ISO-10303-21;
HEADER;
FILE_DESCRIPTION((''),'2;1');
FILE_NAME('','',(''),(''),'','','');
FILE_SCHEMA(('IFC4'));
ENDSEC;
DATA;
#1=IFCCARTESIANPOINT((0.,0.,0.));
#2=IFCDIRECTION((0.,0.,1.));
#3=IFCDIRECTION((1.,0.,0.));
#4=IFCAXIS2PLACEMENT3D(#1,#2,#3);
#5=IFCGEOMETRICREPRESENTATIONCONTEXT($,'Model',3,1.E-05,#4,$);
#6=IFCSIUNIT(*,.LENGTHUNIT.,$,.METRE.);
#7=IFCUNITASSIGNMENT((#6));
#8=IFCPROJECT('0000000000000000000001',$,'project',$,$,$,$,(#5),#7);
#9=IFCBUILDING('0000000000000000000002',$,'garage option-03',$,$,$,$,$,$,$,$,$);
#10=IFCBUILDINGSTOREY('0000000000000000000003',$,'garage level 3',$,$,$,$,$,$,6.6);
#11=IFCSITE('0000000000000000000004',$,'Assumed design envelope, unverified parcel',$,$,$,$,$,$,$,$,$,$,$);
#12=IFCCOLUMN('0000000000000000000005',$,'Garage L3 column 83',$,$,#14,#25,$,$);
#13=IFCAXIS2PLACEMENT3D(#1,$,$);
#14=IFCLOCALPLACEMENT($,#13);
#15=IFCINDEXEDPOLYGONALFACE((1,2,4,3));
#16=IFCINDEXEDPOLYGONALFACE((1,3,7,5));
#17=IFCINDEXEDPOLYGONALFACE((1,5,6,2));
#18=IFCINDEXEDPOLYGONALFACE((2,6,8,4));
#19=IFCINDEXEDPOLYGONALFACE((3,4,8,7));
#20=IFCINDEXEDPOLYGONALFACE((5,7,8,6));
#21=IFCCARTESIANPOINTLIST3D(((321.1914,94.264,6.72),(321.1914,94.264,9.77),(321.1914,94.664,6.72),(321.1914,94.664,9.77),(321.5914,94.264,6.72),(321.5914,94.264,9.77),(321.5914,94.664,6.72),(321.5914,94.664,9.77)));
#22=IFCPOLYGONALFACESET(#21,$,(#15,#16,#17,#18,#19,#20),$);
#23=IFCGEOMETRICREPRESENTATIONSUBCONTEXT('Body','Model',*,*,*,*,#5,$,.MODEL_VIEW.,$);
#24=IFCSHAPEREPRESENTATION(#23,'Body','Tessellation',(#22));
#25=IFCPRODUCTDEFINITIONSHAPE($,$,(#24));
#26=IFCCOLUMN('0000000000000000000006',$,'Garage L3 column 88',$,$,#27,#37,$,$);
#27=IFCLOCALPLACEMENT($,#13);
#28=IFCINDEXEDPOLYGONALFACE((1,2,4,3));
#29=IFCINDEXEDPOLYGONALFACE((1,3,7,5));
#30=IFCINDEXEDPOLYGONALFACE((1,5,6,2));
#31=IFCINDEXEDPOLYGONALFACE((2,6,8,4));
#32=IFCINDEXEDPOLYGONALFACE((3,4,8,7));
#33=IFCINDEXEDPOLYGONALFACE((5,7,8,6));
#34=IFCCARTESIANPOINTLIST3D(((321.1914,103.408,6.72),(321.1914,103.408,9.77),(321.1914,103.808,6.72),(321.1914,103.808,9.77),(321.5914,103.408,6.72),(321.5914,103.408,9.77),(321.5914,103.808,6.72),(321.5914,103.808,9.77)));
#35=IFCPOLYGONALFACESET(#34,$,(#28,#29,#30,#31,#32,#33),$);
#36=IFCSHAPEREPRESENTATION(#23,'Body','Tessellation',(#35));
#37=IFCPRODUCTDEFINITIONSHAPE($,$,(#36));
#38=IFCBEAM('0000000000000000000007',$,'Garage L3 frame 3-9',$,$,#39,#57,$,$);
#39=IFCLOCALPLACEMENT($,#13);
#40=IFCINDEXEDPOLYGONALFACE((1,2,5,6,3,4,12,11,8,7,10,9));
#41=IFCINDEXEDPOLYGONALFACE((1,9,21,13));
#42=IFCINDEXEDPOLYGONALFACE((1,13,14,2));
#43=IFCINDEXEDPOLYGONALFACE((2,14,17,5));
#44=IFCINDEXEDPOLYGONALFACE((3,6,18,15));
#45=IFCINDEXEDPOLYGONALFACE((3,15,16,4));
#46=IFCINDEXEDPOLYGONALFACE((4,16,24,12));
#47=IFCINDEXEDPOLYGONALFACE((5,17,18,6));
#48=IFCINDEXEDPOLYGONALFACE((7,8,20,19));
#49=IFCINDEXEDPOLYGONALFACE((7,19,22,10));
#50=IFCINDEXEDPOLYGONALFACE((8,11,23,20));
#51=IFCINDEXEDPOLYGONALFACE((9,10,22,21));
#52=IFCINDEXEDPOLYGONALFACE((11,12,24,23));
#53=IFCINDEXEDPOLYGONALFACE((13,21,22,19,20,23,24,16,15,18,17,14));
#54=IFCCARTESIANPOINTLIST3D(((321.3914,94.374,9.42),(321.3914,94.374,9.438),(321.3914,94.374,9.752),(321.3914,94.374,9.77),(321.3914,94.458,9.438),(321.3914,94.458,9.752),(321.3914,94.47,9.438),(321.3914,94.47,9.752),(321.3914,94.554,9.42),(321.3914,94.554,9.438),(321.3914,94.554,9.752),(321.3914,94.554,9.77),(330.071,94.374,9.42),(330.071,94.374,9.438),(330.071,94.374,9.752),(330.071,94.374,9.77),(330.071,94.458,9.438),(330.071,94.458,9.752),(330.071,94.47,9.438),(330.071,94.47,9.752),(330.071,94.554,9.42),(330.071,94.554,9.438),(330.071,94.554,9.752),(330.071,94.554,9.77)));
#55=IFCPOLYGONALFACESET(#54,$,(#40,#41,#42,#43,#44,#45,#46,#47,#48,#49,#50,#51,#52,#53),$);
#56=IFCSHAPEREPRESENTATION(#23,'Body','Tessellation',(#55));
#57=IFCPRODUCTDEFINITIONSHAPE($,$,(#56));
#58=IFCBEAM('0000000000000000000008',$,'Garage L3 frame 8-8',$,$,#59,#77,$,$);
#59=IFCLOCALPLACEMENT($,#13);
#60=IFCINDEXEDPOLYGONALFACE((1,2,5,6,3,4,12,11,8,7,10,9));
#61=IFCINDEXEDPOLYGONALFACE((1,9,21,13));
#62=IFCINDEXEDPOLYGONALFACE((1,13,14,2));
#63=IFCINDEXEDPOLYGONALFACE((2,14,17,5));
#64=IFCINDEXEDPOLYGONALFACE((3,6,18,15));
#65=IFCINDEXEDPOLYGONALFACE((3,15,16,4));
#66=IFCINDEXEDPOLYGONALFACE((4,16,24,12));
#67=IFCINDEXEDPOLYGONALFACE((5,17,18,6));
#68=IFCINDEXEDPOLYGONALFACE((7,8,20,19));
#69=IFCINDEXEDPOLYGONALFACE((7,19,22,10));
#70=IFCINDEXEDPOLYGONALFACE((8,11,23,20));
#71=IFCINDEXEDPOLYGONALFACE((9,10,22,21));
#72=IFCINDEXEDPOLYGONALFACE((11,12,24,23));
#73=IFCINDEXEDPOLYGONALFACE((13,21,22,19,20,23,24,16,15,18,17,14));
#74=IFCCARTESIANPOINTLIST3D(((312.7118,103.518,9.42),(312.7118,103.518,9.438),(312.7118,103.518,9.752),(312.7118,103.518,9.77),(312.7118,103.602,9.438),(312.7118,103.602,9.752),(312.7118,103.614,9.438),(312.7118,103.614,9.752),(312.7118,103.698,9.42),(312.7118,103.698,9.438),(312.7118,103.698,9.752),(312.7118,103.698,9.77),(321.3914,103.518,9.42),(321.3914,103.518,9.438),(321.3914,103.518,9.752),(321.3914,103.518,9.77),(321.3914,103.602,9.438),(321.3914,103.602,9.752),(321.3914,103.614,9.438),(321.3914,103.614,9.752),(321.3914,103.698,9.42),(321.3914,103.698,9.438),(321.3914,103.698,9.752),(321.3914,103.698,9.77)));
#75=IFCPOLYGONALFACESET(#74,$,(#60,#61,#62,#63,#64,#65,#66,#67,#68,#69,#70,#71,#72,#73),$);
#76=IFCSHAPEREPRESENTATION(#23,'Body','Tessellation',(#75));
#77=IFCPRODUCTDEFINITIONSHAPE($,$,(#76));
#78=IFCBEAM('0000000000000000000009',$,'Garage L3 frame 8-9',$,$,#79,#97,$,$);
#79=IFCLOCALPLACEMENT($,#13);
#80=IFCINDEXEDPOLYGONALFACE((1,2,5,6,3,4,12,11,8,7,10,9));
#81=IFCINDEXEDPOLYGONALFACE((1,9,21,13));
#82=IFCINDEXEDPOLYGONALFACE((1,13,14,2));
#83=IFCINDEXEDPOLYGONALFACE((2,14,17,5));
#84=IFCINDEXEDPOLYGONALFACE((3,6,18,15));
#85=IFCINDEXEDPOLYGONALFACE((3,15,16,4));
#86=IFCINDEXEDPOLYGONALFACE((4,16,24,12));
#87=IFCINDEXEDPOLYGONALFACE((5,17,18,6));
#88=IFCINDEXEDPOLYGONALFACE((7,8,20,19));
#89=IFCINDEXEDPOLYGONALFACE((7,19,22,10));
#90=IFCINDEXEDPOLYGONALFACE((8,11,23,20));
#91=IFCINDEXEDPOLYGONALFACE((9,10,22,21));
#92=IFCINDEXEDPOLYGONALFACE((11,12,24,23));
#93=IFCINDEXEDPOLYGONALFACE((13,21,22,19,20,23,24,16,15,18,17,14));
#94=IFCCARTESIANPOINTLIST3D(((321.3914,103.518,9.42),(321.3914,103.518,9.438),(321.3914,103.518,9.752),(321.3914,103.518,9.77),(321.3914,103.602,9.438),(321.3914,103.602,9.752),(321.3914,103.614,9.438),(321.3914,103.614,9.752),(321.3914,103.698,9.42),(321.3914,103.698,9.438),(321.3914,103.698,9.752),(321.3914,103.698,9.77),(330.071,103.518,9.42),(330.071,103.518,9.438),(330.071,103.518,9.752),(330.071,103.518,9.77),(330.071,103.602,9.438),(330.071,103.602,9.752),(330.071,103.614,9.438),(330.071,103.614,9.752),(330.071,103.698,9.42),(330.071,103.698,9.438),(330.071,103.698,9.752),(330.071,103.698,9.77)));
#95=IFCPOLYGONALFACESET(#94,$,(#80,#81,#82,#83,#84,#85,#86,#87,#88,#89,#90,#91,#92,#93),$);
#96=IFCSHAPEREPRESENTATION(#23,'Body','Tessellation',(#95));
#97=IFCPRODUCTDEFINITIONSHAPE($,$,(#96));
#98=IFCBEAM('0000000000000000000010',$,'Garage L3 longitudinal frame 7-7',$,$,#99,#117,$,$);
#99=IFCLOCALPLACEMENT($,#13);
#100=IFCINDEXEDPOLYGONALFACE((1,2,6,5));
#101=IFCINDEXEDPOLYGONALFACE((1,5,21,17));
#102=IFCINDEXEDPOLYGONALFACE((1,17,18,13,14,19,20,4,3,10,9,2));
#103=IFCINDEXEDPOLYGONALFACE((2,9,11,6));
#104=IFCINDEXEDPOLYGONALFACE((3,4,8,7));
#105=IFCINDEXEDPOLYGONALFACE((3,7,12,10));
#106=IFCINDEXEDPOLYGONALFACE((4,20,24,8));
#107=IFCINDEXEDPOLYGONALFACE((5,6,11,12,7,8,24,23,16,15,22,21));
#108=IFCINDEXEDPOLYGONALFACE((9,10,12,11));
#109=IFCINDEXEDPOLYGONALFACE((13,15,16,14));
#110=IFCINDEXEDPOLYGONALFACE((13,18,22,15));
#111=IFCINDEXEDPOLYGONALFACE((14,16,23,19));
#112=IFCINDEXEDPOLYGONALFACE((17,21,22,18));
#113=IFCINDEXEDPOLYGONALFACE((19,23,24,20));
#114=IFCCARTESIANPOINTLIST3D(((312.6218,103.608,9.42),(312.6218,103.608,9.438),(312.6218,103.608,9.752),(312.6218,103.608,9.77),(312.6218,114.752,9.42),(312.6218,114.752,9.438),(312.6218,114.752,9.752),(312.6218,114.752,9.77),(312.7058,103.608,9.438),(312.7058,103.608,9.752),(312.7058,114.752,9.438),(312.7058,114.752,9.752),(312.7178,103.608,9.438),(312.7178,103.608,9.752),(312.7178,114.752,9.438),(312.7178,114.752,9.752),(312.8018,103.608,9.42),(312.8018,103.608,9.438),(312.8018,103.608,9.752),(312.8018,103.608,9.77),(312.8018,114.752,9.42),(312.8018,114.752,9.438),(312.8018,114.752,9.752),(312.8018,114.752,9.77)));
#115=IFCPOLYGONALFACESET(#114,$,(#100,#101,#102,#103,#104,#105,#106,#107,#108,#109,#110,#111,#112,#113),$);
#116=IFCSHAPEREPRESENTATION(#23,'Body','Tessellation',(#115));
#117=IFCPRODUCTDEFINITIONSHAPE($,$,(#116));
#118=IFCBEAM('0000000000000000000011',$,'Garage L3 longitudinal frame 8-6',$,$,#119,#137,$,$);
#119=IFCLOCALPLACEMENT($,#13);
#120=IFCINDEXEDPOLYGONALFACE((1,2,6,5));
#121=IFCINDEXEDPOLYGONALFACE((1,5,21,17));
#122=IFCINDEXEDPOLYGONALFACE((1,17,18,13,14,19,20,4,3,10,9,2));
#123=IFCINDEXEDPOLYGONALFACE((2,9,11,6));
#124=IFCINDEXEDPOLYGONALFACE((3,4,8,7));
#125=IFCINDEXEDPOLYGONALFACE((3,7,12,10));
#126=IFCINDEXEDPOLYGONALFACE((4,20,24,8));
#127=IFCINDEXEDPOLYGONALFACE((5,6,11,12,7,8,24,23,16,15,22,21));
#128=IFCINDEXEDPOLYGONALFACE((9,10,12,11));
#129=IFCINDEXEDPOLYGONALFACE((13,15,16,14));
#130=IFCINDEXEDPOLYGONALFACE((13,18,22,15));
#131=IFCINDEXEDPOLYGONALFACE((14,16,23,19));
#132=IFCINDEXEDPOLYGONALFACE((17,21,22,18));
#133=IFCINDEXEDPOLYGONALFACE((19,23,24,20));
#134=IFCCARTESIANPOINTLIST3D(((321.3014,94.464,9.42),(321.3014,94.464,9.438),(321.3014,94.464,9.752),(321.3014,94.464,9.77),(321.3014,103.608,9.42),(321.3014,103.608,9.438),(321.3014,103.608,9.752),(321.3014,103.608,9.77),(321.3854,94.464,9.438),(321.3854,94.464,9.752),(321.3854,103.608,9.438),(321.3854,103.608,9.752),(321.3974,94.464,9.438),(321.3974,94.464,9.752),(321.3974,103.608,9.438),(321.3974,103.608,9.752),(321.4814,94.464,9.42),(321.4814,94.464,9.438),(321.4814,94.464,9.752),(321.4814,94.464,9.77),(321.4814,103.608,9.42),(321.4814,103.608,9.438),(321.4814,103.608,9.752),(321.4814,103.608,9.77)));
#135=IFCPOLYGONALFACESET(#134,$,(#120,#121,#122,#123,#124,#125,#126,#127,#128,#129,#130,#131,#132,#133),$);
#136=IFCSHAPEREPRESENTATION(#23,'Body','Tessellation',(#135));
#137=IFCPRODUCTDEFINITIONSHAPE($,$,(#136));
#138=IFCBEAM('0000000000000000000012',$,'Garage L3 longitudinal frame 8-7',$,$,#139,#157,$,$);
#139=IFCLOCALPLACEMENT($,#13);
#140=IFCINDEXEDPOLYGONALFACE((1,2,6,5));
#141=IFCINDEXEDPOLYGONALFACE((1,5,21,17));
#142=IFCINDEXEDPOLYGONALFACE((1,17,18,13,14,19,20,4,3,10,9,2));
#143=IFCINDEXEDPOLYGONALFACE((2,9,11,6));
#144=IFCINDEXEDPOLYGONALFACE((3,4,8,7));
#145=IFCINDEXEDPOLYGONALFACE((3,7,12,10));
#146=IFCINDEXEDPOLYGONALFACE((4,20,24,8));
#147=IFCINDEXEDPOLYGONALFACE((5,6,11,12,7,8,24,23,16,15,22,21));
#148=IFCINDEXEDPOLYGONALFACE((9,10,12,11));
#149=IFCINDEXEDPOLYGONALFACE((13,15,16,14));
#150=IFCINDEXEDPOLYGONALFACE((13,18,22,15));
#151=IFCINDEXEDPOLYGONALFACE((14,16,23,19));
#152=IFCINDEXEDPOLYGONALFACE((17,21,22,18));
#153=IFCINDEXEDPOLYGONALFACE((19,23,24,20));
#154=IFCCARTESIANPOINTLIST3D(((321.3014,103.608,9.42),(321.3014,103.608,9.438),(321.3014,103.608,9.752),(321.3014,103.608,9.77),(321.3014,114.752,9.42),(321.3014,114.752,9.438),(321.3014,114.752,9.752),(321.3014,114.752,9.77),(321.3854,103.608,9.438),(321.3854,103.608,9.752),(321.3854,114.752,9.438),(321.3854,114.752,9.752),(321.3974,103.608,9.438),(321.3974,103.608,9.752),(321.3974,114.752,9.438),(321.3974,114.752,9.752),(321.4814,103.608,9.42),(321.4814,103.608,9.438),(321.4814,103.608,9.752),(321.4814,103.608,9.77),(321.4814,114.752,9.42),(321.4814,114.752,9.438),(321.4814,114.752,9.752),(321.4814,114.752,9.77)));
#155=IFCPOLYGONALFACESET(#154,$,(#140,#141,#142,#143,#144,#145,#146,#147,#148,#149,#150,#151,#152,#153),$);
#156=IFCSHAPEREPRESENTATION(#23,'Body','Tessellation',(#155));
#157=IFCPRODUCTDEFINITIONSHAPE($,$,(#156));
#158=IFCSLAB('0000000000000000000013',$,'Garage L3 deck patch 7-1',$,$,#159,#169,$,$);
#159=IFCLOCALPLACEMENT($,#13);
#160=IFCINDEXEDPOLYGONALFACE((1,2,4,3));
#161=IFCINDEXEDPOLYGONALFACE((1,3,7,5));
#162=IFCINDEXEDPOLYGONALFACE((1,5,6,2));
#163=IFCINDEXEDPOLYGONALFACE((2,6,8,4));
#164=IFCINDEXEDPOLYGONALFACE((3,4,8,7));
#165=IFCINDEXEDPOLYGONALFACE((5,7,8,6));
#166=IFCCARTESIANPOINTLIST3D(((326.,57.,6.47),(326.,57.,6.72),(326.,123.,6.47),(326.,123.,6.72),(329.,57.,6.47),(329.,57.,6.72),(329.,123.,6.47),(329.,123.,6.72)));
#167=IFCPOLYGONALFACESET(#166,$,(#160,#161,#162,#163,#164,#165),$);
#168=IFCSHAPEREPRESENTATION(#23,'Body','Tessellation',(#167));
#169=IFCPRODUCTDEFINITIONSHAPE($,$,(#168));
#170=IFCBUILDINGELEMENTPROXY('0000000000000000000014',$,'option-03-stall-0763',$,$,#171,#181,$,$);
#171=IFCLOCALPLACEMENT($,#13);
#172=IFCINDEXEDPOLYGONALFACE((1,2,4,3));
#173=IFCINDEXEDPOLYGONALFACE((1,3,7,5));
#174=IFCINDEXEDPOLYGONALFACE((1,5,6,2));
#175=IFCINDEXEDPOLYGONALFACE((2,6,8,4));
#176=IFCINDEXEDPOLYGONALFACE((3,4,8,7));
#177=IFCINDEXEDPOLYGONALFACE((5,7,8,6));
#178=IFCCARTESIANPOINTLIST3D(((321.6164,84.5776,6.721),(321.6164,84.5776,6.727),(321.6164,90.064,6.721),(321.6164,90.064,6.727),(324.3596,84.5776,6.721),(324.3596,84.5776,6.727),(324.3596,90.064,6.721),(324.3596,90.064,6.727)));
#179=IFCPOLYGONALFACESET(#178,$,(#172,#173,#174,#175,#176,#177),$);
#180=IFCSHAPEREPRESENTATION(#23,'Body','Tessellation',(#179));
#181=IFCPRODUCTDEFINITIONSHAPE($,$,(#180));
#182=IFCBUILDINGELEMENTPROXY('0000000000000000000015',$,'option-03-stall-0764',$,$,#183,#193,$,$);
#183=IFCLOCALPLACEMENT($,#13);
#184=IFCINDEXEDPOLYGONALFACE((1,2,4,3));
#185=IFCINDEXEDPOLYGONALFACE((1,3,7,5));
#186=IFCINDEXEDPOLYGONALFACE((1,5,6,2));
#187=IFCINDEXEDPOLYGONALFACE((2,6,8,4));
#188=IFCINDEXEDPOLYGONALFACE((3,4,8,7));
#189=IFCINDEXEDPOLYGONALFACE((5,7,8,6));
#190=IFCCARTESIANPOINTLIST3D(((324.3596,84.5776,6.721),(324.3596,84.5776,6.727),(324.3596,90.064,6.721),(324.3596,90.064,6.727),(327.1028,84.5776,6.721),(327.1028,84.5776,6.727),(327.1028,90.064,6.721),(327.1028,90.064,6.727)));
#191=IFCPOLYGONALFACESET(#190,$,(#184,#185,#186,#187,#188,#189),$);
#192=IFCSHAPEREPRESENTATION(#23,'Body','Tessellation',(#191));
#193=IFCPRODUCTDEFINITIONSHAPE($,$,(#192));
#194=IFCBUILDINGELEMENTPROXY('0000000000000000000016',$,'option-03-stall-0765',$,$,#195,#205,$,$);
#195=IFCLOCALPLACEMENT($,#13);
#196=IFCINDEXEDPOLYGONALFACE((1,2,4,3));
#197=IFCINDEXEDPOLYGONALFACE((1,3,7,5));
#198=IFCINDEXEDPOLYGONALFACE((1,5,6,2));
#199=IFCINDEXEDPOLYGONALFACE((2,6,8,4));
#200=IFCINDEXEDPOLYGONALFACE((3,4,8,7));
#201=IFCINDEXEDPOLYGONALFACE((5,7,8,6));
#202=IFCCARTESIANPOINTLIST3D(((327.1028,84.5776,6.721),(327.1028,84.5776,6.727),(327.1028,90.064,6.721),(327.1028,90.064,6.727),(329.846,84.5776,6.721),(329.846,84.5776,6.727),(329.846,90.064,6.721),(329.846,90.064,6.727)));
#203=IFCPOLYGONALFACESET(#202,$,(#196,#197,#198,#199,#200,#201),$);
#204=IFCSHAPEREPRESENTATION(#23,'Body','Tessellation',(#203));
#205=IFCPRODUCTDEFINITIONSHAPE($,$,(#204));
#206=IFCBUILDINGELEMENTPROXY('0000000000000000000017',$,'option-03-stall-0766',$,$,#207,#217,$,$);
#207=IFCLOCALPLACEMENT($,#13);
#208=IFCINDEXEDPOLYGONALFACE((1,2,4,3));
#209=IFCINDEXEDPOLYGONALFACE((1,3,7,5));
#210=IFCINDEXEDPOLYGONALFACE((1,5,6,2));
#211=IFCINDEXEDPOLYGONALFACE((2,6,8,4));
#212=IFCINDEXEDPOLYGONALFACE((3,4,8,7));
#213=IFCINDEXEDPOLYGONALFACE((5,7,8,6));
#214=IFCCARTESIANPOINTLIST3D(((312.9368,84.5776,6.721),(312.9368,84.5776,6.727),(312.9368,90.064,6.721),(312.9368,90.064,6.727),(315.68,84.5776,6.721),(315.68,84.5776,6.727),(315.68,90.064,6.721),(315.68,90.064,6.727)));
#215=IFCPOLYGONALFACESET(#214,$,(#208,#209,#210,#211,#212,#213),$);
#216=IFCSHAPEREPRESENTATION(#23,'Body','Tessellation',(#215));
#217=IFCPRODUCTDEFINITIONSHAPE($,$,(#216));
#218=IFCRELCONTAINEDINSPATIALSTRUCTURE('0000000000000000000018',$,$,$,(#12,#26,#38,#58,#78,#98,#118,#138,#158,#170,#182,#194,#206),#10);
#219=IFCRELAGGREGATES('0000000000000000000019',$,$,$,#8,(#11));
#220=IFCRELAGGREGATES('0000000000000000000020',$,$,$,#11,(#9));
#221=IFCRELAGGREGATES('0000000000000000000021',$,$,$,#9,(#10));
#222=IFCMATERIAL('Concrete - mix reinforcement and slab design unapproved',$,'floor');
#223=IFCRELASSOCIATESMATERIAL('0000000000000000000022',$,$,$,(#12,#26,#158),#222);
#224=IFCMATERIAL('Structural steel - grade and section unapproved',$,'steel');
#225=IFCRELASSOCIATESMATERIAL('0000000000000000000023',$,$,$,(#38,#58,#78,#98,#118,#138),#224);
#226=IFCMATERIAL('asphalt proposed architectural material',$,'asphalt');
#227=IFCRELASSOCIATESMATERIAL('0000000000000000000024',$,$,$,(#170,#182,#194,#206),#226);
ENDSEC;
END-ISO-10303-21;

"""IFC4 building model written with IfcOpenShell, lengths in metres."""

from ifc_helpers import new_model, si_unit, frame, origin_with_axes, place, context, subcontext, project, spatial, rectangle, i_section, extrude, material, element, save


model = new_model("IFC4")

# Units and contexts
model_context = context("Model", 3, precision=1e-05, world=origin_with_axes())
body_context = subcontext(model_context, "Body", "Model", "MODEL_VIEW")
ifc_project = project(units=[si_unit("LENGTHUNIT", "METRE")], contexts=[model_context])

# Site, building, storey
site = spatial("IfcSite", under=ifc_project, Name="Assumed design envelope, unverified parcel")
building = spatial("IfcBuilding", under=site, Name="garage option-03")
storey = spatial("IfcBuildingStorey", under=building, Name="garage level 3", Elevation=6.6)

# Columns
ifc_material_1 = material(Name="Concrete - mix reinforcement and slab design unapproved", Category="floor")
for number, where, z_axis, x_axis, name in (
    (1, (321.3914, 94.464, 6.72), (0.0, 0.0, 1.0), (1.0, 0.0, 0.0), "Garage L3 column 83"),
    (2, (321.3914, 103.608, 6.72), (0.0, 0.0, 1.0), (1.0, 0.0, 0.0), "Garage L3 column 88"),
):
    element("IfcColumn", number, at=place(None, frame(where, z_axis=z_axis, x_axis=x_axis)), inside=storey, material=ifc_material_1, Name=name, context=body_context, shape_type="SweptSolid", body=[
        extrude(rectangle(XDim=0.4, YDim=0.4), origin_with_axes(), (0.0, 0.0, 1.0), 3.05),
    ])

# Beams
ifc_material_2 = material(Name="Structural steel - grade and section unapproved", Category="steel")
beam_1_placement = place(None, frame((321.3914, 94.464, 9.595), z_axis=(1.0, 0.0, 0.0), x_axis=(0.0, 1.0, 0.0)))
element("IfcBeam", 3, at=beam_1_placement, inside=storey, material=ifc_material_2, Name="Garage L3 frame 3-9", context=body_context, shape_type="SweptSolid", body=[
    extrude(i_section(OverallWidth=0.18, OverallDepth=0.35, WebThickness=0.012, FlangeThickness=0.018, FilletRadius=0.0), origin_with_axes(), (0.0, 0.0, 1.0), 8.6796),
])
beam_2_placement = place(None, frame((312.7118, 103.608, 9.595), z_axis=(1.0, 0.0, 0.0), x_axis=(0.0, 1.0, 0.0)))
element("IfcBeam", 4, at=beam_2_placement, inside=storey, material=ifc_material_2, Name="Garage L3 frame 8-8", context=body_context, shape_type="SweptSolid", body=[
    extrude(i_section(OverallWidth=0.18, OverallDepth=0.35, WebThickness=0.012, FlangeThickness=0.018, FilletRadius=0.0), origin_with_axes(), (0.0, 0.0, 1.0), 8.6796),
])
beam_3_placement = place(None, frame((321.3914, 103.608, 9.595), z_axis=(1.0, 0.0, 0.0), x_axis=(0.0, 1.0, 0.0)))
element("IfcBeam", 5, at=beam_3_placement, inside=storey, material=ifc_material_2, Name="Garage L3 frame 8-9", context=body_context, shape_type="SweptSolid", body=[
    extrude(i_section(OverallWidth=0.18, OverallDepth=0.35, WebThickness=0.012, FlangeThickness=0.018, FilletRadius=0.0), origin_with_axes(), (0.0, 0.0, 1.0), 8.6796),
])
beam_4_placement = place(None, frame((312.7118, 103.608, 9.595), z_axis=(0.0, 1.0, 0.0), x_axis=(-1.0, 0.0, 0.0)))
element("IfcBeam", 6, at=beam_4_placement, inside=storey, material=ifc_material_2, Name="Garage L3 longitudinal frame 7-7", context=body_context, shape_type="SweptSolid", body=[
    extrude(i_section(OverallWidth=0.18, OverallDepth=0.35, WebThickness=0.012, FlangeThickness=0.018, FilletRadius=0.0), origin_with_axes(), (0.0, 0.0, 1.0), 11.144),
])
beam_5_placement = place(None, frame((321.3914, 94.464, 9.595), z_axis=(0.0, 1.0, 0.0), x_axis=(-1.0, 0.0, 0.0)))
element("IfcBeam", 7, at=beam_5_placement, inside=storey, material=ifc_material_2, Name="Garage L3 longitudinal frame 8-6", context=body_context, shape_type="SweptSolid", body=[
    extrude(i_section(OverallWidth=0.18, OverallDepth=0.35, WebThickness=0.012, FlangeThickness=0.018, FilletRadius=0.0), origin_with_axes(), (0.0, 0.0, 1.0), 9.144),
])
beam_6_placement = place(None, frame((321.3914, 103.608, 9.595), z_axis=(0.0, 1.0, 0.0), x_axis=(-1.0, 0.0, 0.0)))
element("IfcBeam", 8, at=beam_6_placement, inside=storey, material=ifc_material_2, Name="Garage L3 longitudinal frame 8-7", context=body_context, shape_type="SweptSolid", body=[
    extrude(i_section(OverallWidth=0.18, OverallDepth=0.35, WebThickness=0.012, FlangeThickness=0.018, FilletRadius=0.0), origin_with_axes(), (0.0, 0.0, 1.0), 11.144),
])

# Slab
slab_placement = place(None, frame((327.5, 90.0, 6.47), z_axis=(0.0, 0.0, 1.0), x_axis=(1.0, 0.0, 0.0)))
element("IfcSlab", 9, at=slab_placement, inside=storey, material=ifc_material_1, Name="Garage L3 deck patch 7-1", context=body_context, shape_type="SweptSolid", body=[
    extrude(rectangle(XDim=3.0, YDim=66.0), origin_with_axes(), (0.0, 0.0, 1.0), 0.25),
])

# Building element proxies
ifc_material_3 = material(Name="asphalt proposed architectural material", Category="asphalt")
for number, where, z_axis, x_axis, name in (
    (10, (322.988, 87.3208, 6.721), (0.0, 0.0, 1.0), (1.0, 0.0, 0.0), "option-03-stall-0763"),
    (11, (325.7312, 87.3208, 6.721), (0.0, 0.0, 1.0), (1.0, 0.0, 0.0), "option-03-stall-0764"),
    (12, (328.4744, 87.3208, 6.721), (0.0, 0.0, 1.0), (1.0, 0.0, 0.0), "option-03-stall-0765"),
    (13, (314.3084, 87.3208, 6.721), (0.0, 0.0, 1.0), (1.0, 0.0, 0.0), "option-03-stall-0766"),
):
    element("IfcBuildingElementProxy", number, at=place(None, frame(where, z_axis=z_axis, x_axis=x_axis)), inside=storey, material=ifc_material_3, Name=name, context=body_context, shape_type="SweptSolid", body=[
        extrude(rectangle(XDim=2.7432, YDim=5.4864), origin_with_axes(), (0.0, 0.0, 1.0), 0.006),
    ])

save(model, "model.ifc")
